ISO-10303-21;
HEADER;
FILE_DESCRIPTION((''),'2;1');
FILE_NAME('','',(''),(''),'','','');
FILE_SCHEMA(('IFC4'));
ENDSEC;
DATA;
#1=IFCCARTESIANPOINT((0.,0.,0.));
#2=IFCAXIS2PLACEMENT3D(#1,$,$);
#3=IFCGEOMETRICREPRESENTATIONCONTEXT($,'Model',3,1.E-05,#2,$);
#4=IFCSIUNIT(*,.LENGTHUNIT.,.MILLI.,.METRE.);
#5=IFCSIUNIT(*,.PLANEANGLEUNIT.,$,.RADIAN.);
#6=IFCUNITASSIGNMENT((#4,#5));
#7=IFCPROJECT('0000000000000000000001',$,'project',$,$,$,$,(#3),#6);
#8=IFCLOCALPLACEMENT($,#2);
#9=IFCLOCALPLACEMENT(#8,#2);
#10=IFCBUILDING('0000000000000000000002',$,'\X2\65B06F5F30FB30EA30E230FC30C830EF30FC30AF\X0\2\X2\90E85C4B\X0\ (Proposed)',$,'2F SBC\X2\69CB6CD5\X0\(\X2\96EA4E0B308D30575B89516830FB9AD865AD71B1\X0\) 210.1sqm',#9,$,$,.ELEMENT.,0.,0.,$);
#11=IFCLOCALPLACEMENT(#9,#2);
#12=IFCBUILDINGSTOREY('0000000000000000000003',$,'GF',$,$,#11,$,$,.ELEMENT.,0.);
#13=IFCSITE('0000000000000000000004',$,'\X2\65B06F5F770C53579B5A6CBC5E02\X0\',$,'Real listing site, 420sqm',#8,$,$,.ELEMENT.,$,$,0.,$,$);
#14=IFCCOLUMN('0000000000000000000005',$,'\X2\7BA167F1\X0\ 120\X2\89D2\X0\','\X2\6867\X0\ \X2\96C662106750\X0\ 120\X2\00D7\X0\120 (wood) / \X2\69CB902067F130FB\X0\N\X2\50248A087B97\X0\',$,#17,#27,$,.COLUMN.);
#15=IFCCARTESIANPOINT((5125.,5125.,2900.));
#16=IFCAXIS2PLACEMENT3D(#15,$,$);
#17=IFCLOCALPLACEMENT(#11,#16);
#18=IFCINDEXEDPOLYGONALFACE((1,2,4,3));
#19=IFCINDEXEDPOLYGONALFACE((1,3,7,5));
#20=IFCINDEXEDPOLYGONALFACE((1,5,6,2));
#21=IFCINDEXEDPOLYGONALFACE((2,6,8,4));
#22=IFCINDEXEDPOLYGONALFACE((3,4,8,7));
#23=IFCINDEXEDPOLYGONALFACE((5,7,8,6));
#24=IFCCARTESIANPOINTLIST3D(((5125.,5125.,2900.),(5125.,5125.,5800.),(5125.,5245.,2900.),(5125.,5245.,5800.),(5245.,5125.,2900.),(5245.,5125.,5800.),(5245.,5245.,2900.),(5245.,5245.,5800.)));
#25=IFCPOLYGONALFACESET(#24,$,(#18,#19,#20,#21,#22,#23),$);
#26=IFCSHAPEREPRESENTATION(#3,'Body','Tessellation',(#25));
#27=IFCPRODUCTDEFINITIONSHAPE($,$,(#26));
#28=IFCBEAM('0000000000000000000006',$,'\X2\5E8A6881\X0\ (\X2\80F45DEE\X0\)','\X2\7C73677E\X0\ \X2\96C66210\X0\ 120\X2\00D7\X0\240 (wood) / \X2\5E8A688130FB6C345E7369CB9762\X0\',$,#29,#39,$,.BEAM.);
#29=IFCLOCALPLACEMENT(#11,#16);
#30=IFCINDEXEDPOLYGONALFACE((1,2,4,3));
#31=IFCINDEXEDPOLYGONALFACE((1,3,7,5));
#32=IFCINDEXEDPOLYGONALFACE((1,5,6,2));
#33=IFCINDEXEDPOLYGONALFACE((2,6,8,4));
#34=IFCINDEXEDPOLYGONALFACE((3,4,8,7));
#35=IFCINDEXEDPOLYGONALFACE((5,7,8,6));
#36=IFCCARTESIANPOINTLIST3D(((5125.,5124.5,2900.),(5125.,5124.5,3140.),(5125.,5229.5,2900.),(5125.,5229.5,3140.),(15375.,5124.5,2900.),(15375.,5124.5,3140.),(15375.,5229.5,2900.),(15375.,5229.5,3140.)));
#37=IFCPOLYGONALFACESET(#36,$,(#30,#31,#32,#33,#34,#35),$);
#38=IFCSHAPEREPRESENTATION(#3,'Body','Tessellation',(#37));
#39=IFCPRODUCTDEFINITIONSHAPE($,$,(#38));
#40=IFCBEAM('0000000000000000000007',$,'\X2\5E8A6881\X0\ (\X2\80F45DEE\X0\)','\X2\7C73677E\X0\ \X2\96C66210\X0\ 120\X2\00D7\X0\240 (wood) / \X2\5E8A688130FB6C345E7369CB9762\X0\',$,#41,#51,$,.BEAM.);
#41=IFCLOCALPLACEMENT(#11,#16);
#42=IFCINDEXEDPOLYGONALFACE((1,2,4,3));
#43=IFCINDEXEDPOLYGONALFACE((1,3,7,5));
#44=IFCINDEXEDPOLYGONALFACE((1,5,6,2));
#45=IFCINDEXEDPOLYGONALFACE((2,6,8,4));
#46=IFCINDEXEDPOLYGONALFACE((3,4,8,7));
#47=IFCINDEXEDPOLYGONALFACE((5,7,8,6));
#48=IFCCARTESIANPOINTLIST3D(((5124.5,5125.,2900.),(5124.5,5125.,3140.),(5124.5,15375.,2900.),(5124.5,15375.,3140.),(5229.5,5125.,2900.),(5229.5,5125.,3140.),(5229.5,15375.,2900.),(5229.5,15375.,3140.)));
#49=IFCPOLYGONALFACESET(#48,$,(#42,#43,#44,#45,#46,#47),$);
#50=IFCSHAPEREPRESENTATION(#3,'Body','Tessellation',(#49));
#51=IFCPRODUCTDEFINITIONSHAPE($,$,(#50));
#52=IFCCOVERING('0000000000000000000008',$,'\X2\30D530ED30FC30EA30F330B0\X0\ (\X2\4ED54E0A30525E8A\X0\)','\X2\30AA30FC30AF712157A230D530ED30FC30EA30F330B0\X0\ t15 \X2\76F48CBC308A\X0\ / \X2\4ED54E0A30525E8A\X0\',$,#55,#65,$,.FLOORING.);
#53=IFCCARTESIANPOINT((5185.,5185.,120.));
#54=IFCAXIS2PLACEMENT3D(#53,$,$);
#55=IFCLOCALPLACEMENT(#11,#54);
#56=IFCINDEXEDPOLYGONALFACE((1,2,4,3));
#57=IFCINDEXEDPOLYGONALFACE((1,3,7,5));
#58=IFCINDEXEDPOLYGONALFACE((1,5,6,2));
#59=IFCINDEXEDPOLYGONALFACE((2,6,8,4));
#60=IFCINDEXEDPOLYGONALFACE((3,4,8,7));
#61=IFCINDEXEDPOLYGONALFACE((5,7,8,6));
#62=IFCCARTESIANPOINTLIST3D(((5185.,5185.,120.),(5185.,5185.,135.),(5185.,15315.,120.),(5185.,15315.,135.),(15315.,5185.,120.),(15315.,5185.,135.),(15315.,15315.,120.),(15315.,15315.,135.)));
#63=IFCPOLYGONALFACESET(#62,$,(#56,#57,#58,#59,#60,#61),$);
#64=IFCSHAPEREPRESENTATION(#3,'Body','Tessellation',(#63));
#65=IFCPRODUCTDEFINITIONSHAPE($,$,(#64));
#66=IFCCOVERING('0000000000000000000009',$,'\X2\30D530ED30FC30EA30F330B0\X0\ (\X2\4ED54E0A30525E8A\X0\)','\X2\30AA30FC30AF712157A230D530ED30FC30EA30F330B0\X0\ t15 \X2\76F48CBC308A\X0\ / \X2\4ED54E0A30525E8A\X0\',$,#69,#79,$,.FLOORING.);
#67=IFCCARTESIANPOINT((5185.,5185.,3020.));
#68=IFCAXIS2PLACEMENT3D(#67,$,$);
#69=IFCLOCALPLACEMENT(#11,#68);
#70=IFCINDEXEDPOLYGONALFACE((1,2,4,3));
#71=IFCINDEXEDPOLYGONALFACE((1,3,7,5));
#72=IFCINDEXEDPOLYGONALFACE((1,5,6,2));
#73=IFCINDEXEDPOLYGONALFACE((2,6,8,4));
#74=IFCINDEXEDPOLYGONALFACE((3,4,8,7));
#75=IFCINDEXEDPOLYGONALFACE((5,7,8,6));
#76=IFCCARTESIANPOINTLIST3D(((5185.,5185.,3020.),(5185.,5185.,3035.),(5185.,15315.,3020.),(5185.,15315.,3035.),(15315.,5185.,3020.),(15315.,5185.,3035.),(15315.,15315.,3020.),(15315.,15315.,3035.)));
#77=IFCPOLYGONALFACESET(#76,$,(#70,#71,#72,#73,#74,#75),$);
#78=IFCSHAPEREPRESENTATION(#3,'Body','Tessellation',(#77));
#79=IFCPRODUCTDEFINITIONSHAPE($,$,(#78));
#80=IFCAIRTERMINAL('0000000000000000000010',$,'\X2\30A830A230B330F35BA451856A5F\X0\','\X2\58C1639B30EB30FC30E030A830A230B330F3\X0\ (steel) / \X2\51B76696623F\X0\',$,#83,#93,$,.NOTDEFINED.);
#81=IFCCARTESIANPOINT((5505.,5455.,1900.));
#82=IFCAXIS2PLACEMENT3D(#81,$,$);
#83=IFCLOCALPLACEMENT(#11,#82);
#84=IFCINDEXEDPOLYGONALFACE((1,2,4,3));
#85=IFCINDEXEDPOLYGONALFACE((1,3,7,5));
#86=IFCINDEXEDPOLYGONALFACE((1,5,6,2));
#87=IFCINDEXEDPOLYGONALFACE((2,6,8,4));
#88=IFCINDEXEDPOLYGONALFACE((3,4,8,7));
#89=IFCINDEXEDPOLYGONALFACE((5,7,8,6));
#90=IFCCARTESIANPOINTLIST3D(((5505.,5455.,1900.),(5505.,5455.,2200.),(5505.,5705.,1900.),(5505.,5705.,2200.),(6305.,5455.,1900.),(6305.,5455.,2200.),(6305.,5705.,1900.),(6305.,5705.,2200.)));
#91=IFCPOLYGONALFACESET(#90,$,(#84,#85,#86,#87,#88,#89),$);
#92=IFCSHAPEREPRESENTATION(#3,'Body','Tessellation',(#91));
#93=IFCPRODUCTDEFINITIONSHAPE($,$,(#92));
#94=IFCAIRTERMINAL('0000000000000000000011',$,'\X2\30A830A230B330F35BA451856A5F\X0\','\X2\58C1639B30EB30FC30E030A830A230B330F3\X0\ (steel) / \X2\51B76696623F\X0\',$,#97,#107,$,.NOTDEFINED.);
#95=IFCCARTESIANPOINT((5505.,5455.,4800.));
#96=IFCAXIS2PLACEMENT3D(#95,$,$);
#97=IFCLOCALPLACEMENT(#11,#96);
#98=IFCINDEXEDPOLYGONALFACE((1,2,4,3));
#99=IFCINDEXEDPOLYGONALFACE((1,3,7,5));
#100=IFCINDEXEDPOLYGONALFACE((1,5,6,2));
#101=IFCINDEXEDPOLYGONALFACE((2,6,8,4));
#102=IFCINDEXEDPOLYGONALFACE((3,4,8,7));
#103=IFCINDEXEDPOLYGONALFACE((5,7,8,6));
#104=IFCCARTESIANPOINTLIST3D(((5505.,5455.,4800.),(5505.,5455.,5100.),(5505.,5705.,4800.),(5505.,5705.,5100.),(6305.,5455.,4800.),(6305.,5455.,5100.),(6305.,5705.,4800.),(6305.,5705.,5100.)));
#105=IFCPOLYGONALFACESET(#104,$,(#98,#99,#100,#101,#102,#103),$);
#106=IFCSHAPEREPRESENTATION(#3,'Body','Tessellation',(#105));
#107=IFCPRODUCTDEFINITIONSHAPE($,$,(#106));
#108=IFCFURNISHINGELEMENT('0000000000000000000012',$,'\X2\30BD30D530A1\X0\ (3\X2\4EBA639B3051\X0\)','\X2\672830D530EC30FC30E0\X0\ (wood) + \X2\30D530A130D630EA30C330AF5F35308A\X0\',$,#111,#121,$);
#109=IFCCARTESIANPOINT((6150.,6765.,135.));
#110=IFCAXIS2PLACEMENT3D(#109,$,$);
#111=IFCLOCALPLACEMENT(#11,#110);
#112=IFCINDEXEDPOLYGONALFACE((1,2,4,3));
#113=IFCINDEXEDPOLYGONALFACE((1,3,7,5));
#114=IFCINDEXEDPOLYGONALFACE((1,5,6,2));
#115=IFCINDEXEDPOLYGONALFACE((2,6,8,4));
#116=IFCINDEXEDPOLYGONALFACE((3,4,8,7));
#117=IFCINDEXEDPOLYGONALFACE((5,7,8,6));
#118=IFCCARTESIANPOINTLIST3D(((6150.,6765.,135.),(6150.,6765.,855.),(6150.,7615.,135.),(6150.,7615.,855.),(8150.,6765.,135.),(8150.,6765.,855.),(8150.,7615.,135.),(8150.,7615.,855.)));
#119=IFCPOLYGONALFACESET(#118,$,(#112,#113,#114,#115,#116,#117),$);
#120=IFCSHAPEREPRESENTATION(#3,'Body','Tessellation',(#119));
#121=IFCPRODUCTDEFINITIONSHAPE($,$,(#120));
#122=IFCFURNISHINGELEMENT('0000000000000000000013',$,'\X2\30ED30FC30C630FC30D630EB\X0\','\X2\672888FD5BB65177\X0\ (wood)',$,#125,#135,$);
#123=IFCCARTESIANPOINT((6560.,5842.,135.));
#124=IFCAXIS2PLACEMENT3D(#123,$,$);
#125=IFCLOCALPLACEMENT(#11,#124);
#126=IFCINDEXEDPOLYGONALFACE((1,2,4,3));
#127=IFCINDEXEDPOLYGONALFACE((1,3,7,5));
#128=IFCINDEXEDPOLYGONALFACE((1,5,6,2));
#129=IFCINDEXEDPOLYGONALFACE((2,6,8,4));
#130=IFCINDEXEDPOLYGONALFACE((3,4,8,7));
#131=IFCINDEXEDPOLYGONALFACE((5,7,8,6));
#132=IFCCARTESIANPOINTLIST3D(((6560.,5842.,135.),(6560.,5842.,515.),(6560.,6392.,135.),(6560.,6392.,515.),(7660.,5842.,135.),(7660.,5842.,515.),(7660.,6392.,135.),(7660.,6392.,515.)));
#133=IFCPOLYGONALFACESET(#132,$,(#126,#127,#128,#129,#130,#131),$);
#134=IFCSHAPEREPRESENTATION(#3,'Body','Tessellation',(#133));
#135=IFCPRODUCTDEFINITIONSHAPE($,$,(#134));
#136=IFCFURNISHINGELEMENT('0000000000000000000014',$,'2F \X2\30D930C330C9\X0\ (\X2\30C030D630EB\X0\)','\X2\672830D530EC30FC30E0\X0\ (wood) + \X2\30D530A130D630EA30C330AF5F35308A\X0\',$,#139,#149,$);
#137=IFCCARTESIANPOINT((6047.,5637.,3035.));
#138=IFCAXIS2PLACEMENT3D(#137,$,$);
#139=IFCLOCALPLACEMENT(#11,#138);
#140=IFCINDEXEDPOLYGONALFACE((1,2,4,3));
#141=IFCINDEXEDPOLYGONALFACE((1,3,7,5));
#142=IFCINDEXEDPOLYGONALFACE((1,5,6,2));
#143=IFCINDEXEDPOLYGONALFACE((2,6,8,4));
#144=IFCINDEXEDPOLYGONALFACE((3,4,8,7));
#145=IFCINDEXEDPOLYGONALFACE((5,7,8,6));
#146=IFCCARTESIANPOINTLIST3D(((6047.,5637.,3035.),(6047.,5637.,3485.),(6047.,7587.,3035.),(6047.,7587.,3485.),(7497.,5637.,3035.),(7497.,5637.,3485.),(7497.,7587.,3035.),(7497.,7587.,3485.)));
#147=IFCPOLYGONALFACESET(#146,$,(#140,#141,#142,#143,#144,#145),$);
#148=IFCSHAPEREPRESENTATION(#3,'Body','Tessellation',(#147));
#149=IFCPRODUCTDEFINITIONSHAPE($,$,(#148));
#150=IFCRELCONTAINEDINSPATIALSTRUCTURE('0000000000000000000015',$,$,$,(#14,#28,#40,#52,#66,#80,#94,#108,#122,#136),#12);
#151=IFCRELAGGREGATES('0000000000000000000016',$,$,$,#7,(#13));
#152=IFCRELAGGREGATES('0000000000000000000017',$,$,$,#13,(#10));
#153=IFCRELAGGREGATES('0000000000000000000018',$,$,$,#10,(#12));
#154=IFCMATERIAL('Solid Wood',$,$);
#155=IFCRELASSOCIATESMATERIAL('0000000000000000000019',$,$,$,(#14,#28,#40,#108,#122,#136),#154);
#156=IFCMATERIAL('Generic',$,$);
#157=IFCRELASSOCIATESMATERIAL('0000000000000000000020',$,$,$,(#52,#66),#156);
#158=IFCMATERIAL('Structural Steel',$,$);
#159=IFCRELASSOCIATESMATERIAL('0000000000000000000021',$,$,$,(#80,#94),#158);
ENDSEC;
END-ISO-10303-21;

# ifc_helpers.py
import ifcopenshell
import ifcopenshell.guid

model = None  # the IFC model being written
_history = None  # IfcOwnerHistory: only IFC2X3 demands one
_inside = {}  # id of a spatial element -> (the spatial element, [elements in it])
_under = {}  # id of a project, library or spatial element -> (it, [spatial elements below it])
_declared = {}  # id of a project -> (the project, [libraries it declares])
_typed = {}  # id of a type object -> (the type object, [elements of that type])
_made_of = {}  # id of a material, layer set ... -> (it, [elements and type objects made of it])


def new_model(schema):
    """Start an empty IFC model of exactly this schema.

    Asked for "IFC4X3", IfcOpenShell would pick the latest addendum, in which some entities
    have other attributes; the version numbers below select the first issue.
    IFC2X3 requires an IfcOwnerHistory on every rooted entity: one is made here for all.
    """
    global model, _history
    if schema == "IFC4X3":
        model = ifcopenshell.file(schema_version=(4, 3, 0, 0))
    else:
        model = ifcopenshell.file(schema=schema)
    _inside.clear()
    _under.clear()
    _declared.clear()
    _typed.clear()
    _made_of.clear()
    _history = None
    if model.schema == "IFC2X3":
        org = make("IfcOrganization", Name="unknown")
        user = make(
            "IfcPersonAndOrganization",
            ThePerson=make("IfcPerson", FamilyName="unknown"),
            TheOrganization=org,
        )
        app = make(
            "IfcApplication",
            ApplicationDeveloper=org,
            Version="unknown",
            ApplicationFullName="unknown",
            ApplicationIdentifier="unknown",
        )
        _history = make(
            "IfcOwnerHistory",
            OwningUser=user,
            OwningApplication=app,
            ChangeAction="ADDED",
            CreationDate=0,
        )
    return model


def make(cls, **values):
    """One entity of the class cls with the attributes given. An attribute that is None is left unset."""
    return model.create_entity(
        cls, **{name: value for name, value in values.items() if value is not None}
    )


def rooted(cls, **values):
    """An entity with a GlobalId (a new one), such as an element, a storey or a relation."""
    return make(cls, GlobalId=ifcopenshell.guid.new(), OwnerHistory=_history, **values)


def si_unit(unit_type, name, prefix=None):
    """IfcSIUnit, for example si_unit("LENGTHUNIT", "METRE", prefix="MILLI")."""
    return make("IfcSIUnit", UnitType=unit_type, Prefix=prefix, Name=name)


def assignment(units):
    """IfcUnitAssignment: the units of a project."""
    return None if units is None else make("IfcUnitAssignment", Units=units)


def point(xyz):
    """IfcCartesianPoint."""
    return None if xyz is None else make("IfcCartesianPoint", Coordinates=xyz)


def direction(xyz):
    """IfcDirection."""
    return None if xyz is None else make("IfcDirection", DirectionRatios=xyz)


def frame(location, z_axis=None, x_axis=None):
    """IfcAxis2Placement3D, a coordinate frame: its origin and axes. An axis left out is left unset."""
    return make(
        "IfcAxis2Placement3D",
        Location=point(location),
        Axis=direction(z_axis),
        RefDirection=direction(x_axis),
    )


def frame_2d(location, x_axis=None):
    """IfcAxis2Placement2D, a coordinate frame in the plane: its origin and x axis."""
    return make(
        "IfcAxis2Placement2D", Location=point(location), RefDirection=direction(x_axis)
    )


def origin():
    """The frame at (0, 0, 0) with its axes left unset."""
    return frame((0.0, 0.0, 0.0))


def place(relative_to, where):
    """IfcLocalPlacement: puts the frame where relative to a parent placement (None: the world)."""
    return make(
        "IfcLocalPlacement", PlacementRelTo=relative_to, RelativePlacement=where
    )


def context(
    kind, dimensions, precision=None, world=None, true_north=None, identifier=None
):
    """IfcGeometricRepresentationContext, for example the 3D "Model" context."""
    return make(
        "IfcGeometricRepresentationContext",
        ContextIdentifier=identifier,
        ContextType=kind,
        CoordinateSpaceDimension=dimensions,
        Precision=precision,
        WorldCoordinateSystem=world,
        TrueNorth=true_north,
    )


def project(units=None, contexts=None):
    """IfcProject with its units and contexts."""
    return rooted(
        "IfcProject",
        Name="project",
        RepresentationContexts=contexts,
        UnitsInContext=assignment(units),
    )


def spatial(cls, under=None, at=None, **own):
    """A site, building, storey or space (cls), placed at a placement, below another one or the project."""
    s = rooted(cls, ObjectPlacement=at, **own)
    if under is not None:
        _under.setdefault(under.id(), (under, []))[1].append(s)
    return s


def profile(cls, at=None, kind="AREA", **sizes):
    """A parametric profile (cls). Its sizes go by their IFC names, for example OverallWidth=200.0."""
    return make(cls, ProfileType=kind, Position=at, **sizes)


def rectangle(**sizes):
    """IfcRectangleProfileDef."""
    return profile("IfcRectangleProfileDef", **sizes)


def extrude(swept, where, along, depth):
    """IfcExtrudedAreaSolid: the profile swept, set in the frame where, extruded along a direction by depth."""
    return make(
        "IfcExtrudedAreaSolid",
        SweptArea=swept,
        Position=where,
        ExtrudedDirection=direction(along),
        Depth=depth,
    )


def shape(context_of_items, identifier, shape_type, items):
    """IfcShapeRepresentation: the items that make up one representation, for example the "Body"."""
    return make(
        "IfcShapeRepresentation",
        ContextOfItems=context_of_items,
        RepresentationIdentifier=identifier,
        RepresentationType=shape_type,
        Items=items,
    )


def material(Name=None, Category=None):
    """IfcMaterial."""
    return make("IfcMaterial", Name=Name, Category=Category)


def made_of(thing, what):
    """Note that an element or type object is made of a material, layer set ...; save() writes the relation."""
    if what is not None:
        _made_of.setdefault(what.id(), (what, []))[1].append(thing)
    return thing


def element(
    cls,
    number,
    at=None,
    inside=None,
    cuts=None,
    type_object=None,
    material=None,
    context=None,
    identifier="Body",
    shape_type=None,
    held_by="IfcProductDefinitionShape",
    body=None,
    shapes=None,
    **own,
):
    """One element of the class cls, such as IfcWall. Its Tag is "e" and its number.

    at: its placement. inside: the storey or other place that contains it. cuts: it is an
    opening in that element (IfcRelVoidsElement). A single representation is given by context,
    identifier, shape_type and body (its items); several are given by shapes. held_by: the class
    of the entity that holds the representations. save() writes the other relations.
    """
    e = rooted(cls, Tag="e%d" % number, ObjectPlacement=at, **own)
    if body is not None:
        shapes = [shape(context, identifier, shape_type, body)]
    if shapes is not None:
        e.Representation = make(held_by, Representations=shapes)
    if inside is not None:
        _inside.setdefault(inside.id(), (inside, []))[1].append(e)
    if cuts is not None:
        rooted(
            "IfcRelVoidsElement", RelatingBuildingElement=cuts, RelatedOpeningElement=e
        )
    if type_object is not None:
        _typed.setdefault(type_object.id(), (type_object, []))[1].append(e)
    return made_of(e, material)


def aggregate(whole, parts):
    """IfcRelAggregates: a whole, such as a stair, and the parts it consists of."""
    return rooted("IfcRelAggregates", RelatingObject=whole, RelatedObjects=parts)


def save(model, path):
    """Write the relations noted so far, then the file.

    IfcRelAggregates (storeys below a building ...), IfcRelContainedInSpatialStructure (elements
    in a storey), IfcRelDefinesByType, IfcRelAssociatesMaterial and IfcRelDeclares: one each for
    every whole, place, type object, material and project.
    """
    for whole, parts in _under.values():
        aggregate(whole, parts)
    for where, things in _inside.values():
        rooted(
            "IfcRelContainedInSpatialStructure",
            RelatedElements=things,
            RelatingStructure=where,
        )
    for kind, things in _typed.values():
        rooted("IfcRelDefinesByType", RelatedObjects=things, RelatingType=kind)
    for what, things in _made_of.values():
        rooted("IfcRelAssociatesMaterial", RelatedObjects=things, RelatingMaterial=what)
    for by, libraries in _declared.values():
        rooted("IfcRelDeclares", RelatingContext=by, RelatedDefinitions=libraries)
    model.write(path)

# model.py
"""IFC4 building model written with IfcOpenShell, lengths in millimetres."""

from ifc_helpers import new_model, si_unit, frame, frame_2d, origin, place, context, project, spatial, rectangle, extrude, material, element, save


model = new_model("IFC4")

# Units and contexts
model_context = context("Model", 3, precision=1e-05, world=origin())
ifc_project = project(units=[si_unit("LENGTHUNIT", "METRE", prefix="MILLI"), si_unit("PLANEANGLEUNIT", "RADIAN")], contexts=[model_context])

# Site, building, storey
site_placement = place(None, origin())
site = spatial("IfcSite", under=ifc_project, at=site_placement, Name="新潟県南魚沼市", ObjectType="Real listing site, 420sqm", CompositionType="ELEMENT", RefElevation=0.0)
building_placement = place(site_placement, origin())
building = spatial("IfcBuilding", under=site, at=building_placement, Name="新潟・リモートワーク2部屋 (Proposed)", ObjectType="2F SBC構法(雪下ろし安全・高断熱) 210.1sqm", CompositionType="ELEMENT", ElevationOfRefHeight=0.0, ElevationOfTerrain=0.0)
storey_placement = place(building_placement, origin())
storey = spatial("IfcBuildingStorey", under=building, at=storey_placement, Name="GF", CompositionType="ELEMENT", Elevation=0.0)

# Column
ifc_material_1 = material(Name="Solid Wood")
column_1_placement = place(storey_placement, frame((5125.0, 5125.0, 2900.0)))
element("IfcColumn", 1, at=column_1_placement, inside=storey, material=ifc_material_1, Name="管柱 120角", Description="桧 集成材 120×120 (wood) / 構造柱・N値計算", PredefinedType="COLUMN", context=model_context, shape_type="SweptSolid", body=[
    extrude(rectangle(XDim=120.0, YDim=120.0, at=frame_2d((60.0, 60.0))), frame((5125.0, 5125.0, 2900.0)), (0.0, 0.0, 1.0), 2900.0),
])

# Beams
beam_1_placement = place(storey_placement, frame((5125.0, 5125.0, 2900.0)))
element("IfcBeam", 2, at=beam_1_placement, inside=storey, material=ifc_material_1, Name="床梁 (胴差)", Description="米松 集成 120×240 (wood) / 床梁・水平構面", PredefinedType="BEAM", context=model_context, shape_type="SweptSolid", body=[
    extrude(rectangle(XDim=10250.0, YDim=105.0, at=frame_2d((5125.0, 52.0))), frame((5125.0, 5125.0, 2900.0)), (0.0, 0.0, 1.0), 240.0),
])
beam_2_placement = place(storey_placement, frame((5125.0, 5125.0, 2900.0)))
element("IfcBeam", 3, at=beam_2_placement, inside=storey, material=ifc_material_1, Name="床梁 (胴差)", Description="米松 集成 120×240 (wood) / 床梁・水平構面", PredefinedType="BEAM", context=model_context, shape_type="SweptSolid", body=[
    extrude(rectangle(XDim=105.0, YDim=10250.0, at=frame_2d((52.0, 5125.0))), frame((5125.0, 5125.0, 2900.0)), (0.0, 0.0, 1.0), 240.0),
])

# Coverings
ifc_material_2 = material(Name="Generic")
covering_1_placement = place(storey_placement, frame((5185.0, 5185.0, 120.0)))
element("IfcCovering", 4, at=covering_1_placement, inside=storey, material=ifc_material_2, Name="フローリング (仕上げ床)", Description="オーク無垢フローリング t15 直貼り / 仕上げ床", PredefinedType="FLOORING", context=model_context, shape_type="SweptSolid", body=[
    extrude(rectangle(XDim=10130.0, YDim=10130.0, at=frame_2d((5065.0, 5065.0))), frame((5185.0, 5185.0, 120.0)), (0.0, 0.0, 1.0), 15.0),
])
covering_2_placement = place(storey_placement, frame((5185.0, 5185.0, 3020.0)))
element("IfcCovering", 5, at=covering_2_placement, inside=storey, material=ifc_material_2, Name="フローリング (仕上げ床)", Description="オーク無垢フローリング t15 直貼り / 仕上げ床", PredefinedType="FLOORING", context=model_context, shape_type="SweptSolid", body=[
    extrude(rectangle(XDim=10130.0, YDim=10130.0, at=frame_2d((5065.0, 5065.0))), frame((5185.0, 5185.0, 3020.0)), (0.0, 0.0, 1.0), 15.0),
])

# Air terminals
ifc_material_3 = material(Name="Structural Steel")
air_terminal_1_placement = place(storey_placement, frame((5505.0, 5455.0, 1900.0)))
element("IfcAirTerminal", 6, at=air_terminal_1_placement, inside=storey, material=ifc_material_3, Name="エアコン室内機", Description="壁掛ルームエアコン (steel) / 冷暖房", PredefinedType="NOTDEFINED", context=model_context, shape_type="SweptSolid", body=[
    extrude(rectangle(XDim=800.0, YDim=250.0, at=frame_2d((400.0, 125.0))), frame((5505.0, 5455.0, 1900.0)), (0.0, 0.0, 1.0), 300.0),
])
air_terminal_2_placement = place(storey_placement, frame((5505.0, 5455.0, 4800.0)))
element("IfcAirTerminal", 7, at=air_terminal_2_placement, inside=storey, material=ifc_material_3, Name="エアコン室内機", Description="壁掛ルームエアコン (steel) / 冷暖房", PredefinedType="NOTDEFINED", context=model_context, shape_type="SweptSolid", body=[
    extrude(rectangle(XDim=800.0, YDim=250.0, at=frame_2d((400.0, 125.0))), frame((5505.0, 5455.0, 4800.0)), (0.0, 0.0, 1.0), 300.0),
])

# Furnishing elements
furnishing_1_placement = place(storey_placement, frame((6150.0, 6765.0, 135.0)))
element("IfcFurnishingElement", 8, at=furnishing_1_placement, inside=storey, material=ifc_material_1, Name="ソファ (3人掛け)", Description="木フレーム (wood) + ファブリック張り", context=model_context, shape_type="SweptSolid", body=[
    extrude(rectangle(XDim=2000.0, YDim=850.0, at=frame_2d((1000.0, 425.0))), frame((6150.0, 6765.0, 135.0)), (0.0, 0.0, 1.0), 720.0),
])
furnishing_2_placement = place(storey_placement, frame((6560.0, 5842.0, 135.0)))
element("IfcFurnishingElement", 9, at=furnishing_2_placement, inside=storey, material=ifc_material_1, Name="ローテーブル", Description="木製家具 (wood)", context=model_context, shape_type="SweptSolid", body=[
    extrude(rectangle(XDim=1100.0, YDim=550.0, at=frame_2d((550.0, 275.0))), frame((6560.0, 5842.0, 135.0)), (0.0, 0.0, 1.0), 380.0),
])
furnishing_3_placement = place(storey_placement, frame((6047.0, 5637.0, 3035.0)))
element("IfcFurnishingElement", 10, at=furnishing_3_placement, inside=storey, material=ifc_material_1, Name="2F ベッド (ダブル)", Description="木フレーム (wood) + ファブリック張り", context=model_context, shape_type="SweptSolid", body=[
    extrude(rectangle(XDim=1450.0, YDim=1950.0, at=frame_2d((725.0, 975.0))), frame((6047.0, 5637.0, 3035.0)), (0.0, 0.0, 1.0), 450.0),
])

save(model, "model.ifc")
